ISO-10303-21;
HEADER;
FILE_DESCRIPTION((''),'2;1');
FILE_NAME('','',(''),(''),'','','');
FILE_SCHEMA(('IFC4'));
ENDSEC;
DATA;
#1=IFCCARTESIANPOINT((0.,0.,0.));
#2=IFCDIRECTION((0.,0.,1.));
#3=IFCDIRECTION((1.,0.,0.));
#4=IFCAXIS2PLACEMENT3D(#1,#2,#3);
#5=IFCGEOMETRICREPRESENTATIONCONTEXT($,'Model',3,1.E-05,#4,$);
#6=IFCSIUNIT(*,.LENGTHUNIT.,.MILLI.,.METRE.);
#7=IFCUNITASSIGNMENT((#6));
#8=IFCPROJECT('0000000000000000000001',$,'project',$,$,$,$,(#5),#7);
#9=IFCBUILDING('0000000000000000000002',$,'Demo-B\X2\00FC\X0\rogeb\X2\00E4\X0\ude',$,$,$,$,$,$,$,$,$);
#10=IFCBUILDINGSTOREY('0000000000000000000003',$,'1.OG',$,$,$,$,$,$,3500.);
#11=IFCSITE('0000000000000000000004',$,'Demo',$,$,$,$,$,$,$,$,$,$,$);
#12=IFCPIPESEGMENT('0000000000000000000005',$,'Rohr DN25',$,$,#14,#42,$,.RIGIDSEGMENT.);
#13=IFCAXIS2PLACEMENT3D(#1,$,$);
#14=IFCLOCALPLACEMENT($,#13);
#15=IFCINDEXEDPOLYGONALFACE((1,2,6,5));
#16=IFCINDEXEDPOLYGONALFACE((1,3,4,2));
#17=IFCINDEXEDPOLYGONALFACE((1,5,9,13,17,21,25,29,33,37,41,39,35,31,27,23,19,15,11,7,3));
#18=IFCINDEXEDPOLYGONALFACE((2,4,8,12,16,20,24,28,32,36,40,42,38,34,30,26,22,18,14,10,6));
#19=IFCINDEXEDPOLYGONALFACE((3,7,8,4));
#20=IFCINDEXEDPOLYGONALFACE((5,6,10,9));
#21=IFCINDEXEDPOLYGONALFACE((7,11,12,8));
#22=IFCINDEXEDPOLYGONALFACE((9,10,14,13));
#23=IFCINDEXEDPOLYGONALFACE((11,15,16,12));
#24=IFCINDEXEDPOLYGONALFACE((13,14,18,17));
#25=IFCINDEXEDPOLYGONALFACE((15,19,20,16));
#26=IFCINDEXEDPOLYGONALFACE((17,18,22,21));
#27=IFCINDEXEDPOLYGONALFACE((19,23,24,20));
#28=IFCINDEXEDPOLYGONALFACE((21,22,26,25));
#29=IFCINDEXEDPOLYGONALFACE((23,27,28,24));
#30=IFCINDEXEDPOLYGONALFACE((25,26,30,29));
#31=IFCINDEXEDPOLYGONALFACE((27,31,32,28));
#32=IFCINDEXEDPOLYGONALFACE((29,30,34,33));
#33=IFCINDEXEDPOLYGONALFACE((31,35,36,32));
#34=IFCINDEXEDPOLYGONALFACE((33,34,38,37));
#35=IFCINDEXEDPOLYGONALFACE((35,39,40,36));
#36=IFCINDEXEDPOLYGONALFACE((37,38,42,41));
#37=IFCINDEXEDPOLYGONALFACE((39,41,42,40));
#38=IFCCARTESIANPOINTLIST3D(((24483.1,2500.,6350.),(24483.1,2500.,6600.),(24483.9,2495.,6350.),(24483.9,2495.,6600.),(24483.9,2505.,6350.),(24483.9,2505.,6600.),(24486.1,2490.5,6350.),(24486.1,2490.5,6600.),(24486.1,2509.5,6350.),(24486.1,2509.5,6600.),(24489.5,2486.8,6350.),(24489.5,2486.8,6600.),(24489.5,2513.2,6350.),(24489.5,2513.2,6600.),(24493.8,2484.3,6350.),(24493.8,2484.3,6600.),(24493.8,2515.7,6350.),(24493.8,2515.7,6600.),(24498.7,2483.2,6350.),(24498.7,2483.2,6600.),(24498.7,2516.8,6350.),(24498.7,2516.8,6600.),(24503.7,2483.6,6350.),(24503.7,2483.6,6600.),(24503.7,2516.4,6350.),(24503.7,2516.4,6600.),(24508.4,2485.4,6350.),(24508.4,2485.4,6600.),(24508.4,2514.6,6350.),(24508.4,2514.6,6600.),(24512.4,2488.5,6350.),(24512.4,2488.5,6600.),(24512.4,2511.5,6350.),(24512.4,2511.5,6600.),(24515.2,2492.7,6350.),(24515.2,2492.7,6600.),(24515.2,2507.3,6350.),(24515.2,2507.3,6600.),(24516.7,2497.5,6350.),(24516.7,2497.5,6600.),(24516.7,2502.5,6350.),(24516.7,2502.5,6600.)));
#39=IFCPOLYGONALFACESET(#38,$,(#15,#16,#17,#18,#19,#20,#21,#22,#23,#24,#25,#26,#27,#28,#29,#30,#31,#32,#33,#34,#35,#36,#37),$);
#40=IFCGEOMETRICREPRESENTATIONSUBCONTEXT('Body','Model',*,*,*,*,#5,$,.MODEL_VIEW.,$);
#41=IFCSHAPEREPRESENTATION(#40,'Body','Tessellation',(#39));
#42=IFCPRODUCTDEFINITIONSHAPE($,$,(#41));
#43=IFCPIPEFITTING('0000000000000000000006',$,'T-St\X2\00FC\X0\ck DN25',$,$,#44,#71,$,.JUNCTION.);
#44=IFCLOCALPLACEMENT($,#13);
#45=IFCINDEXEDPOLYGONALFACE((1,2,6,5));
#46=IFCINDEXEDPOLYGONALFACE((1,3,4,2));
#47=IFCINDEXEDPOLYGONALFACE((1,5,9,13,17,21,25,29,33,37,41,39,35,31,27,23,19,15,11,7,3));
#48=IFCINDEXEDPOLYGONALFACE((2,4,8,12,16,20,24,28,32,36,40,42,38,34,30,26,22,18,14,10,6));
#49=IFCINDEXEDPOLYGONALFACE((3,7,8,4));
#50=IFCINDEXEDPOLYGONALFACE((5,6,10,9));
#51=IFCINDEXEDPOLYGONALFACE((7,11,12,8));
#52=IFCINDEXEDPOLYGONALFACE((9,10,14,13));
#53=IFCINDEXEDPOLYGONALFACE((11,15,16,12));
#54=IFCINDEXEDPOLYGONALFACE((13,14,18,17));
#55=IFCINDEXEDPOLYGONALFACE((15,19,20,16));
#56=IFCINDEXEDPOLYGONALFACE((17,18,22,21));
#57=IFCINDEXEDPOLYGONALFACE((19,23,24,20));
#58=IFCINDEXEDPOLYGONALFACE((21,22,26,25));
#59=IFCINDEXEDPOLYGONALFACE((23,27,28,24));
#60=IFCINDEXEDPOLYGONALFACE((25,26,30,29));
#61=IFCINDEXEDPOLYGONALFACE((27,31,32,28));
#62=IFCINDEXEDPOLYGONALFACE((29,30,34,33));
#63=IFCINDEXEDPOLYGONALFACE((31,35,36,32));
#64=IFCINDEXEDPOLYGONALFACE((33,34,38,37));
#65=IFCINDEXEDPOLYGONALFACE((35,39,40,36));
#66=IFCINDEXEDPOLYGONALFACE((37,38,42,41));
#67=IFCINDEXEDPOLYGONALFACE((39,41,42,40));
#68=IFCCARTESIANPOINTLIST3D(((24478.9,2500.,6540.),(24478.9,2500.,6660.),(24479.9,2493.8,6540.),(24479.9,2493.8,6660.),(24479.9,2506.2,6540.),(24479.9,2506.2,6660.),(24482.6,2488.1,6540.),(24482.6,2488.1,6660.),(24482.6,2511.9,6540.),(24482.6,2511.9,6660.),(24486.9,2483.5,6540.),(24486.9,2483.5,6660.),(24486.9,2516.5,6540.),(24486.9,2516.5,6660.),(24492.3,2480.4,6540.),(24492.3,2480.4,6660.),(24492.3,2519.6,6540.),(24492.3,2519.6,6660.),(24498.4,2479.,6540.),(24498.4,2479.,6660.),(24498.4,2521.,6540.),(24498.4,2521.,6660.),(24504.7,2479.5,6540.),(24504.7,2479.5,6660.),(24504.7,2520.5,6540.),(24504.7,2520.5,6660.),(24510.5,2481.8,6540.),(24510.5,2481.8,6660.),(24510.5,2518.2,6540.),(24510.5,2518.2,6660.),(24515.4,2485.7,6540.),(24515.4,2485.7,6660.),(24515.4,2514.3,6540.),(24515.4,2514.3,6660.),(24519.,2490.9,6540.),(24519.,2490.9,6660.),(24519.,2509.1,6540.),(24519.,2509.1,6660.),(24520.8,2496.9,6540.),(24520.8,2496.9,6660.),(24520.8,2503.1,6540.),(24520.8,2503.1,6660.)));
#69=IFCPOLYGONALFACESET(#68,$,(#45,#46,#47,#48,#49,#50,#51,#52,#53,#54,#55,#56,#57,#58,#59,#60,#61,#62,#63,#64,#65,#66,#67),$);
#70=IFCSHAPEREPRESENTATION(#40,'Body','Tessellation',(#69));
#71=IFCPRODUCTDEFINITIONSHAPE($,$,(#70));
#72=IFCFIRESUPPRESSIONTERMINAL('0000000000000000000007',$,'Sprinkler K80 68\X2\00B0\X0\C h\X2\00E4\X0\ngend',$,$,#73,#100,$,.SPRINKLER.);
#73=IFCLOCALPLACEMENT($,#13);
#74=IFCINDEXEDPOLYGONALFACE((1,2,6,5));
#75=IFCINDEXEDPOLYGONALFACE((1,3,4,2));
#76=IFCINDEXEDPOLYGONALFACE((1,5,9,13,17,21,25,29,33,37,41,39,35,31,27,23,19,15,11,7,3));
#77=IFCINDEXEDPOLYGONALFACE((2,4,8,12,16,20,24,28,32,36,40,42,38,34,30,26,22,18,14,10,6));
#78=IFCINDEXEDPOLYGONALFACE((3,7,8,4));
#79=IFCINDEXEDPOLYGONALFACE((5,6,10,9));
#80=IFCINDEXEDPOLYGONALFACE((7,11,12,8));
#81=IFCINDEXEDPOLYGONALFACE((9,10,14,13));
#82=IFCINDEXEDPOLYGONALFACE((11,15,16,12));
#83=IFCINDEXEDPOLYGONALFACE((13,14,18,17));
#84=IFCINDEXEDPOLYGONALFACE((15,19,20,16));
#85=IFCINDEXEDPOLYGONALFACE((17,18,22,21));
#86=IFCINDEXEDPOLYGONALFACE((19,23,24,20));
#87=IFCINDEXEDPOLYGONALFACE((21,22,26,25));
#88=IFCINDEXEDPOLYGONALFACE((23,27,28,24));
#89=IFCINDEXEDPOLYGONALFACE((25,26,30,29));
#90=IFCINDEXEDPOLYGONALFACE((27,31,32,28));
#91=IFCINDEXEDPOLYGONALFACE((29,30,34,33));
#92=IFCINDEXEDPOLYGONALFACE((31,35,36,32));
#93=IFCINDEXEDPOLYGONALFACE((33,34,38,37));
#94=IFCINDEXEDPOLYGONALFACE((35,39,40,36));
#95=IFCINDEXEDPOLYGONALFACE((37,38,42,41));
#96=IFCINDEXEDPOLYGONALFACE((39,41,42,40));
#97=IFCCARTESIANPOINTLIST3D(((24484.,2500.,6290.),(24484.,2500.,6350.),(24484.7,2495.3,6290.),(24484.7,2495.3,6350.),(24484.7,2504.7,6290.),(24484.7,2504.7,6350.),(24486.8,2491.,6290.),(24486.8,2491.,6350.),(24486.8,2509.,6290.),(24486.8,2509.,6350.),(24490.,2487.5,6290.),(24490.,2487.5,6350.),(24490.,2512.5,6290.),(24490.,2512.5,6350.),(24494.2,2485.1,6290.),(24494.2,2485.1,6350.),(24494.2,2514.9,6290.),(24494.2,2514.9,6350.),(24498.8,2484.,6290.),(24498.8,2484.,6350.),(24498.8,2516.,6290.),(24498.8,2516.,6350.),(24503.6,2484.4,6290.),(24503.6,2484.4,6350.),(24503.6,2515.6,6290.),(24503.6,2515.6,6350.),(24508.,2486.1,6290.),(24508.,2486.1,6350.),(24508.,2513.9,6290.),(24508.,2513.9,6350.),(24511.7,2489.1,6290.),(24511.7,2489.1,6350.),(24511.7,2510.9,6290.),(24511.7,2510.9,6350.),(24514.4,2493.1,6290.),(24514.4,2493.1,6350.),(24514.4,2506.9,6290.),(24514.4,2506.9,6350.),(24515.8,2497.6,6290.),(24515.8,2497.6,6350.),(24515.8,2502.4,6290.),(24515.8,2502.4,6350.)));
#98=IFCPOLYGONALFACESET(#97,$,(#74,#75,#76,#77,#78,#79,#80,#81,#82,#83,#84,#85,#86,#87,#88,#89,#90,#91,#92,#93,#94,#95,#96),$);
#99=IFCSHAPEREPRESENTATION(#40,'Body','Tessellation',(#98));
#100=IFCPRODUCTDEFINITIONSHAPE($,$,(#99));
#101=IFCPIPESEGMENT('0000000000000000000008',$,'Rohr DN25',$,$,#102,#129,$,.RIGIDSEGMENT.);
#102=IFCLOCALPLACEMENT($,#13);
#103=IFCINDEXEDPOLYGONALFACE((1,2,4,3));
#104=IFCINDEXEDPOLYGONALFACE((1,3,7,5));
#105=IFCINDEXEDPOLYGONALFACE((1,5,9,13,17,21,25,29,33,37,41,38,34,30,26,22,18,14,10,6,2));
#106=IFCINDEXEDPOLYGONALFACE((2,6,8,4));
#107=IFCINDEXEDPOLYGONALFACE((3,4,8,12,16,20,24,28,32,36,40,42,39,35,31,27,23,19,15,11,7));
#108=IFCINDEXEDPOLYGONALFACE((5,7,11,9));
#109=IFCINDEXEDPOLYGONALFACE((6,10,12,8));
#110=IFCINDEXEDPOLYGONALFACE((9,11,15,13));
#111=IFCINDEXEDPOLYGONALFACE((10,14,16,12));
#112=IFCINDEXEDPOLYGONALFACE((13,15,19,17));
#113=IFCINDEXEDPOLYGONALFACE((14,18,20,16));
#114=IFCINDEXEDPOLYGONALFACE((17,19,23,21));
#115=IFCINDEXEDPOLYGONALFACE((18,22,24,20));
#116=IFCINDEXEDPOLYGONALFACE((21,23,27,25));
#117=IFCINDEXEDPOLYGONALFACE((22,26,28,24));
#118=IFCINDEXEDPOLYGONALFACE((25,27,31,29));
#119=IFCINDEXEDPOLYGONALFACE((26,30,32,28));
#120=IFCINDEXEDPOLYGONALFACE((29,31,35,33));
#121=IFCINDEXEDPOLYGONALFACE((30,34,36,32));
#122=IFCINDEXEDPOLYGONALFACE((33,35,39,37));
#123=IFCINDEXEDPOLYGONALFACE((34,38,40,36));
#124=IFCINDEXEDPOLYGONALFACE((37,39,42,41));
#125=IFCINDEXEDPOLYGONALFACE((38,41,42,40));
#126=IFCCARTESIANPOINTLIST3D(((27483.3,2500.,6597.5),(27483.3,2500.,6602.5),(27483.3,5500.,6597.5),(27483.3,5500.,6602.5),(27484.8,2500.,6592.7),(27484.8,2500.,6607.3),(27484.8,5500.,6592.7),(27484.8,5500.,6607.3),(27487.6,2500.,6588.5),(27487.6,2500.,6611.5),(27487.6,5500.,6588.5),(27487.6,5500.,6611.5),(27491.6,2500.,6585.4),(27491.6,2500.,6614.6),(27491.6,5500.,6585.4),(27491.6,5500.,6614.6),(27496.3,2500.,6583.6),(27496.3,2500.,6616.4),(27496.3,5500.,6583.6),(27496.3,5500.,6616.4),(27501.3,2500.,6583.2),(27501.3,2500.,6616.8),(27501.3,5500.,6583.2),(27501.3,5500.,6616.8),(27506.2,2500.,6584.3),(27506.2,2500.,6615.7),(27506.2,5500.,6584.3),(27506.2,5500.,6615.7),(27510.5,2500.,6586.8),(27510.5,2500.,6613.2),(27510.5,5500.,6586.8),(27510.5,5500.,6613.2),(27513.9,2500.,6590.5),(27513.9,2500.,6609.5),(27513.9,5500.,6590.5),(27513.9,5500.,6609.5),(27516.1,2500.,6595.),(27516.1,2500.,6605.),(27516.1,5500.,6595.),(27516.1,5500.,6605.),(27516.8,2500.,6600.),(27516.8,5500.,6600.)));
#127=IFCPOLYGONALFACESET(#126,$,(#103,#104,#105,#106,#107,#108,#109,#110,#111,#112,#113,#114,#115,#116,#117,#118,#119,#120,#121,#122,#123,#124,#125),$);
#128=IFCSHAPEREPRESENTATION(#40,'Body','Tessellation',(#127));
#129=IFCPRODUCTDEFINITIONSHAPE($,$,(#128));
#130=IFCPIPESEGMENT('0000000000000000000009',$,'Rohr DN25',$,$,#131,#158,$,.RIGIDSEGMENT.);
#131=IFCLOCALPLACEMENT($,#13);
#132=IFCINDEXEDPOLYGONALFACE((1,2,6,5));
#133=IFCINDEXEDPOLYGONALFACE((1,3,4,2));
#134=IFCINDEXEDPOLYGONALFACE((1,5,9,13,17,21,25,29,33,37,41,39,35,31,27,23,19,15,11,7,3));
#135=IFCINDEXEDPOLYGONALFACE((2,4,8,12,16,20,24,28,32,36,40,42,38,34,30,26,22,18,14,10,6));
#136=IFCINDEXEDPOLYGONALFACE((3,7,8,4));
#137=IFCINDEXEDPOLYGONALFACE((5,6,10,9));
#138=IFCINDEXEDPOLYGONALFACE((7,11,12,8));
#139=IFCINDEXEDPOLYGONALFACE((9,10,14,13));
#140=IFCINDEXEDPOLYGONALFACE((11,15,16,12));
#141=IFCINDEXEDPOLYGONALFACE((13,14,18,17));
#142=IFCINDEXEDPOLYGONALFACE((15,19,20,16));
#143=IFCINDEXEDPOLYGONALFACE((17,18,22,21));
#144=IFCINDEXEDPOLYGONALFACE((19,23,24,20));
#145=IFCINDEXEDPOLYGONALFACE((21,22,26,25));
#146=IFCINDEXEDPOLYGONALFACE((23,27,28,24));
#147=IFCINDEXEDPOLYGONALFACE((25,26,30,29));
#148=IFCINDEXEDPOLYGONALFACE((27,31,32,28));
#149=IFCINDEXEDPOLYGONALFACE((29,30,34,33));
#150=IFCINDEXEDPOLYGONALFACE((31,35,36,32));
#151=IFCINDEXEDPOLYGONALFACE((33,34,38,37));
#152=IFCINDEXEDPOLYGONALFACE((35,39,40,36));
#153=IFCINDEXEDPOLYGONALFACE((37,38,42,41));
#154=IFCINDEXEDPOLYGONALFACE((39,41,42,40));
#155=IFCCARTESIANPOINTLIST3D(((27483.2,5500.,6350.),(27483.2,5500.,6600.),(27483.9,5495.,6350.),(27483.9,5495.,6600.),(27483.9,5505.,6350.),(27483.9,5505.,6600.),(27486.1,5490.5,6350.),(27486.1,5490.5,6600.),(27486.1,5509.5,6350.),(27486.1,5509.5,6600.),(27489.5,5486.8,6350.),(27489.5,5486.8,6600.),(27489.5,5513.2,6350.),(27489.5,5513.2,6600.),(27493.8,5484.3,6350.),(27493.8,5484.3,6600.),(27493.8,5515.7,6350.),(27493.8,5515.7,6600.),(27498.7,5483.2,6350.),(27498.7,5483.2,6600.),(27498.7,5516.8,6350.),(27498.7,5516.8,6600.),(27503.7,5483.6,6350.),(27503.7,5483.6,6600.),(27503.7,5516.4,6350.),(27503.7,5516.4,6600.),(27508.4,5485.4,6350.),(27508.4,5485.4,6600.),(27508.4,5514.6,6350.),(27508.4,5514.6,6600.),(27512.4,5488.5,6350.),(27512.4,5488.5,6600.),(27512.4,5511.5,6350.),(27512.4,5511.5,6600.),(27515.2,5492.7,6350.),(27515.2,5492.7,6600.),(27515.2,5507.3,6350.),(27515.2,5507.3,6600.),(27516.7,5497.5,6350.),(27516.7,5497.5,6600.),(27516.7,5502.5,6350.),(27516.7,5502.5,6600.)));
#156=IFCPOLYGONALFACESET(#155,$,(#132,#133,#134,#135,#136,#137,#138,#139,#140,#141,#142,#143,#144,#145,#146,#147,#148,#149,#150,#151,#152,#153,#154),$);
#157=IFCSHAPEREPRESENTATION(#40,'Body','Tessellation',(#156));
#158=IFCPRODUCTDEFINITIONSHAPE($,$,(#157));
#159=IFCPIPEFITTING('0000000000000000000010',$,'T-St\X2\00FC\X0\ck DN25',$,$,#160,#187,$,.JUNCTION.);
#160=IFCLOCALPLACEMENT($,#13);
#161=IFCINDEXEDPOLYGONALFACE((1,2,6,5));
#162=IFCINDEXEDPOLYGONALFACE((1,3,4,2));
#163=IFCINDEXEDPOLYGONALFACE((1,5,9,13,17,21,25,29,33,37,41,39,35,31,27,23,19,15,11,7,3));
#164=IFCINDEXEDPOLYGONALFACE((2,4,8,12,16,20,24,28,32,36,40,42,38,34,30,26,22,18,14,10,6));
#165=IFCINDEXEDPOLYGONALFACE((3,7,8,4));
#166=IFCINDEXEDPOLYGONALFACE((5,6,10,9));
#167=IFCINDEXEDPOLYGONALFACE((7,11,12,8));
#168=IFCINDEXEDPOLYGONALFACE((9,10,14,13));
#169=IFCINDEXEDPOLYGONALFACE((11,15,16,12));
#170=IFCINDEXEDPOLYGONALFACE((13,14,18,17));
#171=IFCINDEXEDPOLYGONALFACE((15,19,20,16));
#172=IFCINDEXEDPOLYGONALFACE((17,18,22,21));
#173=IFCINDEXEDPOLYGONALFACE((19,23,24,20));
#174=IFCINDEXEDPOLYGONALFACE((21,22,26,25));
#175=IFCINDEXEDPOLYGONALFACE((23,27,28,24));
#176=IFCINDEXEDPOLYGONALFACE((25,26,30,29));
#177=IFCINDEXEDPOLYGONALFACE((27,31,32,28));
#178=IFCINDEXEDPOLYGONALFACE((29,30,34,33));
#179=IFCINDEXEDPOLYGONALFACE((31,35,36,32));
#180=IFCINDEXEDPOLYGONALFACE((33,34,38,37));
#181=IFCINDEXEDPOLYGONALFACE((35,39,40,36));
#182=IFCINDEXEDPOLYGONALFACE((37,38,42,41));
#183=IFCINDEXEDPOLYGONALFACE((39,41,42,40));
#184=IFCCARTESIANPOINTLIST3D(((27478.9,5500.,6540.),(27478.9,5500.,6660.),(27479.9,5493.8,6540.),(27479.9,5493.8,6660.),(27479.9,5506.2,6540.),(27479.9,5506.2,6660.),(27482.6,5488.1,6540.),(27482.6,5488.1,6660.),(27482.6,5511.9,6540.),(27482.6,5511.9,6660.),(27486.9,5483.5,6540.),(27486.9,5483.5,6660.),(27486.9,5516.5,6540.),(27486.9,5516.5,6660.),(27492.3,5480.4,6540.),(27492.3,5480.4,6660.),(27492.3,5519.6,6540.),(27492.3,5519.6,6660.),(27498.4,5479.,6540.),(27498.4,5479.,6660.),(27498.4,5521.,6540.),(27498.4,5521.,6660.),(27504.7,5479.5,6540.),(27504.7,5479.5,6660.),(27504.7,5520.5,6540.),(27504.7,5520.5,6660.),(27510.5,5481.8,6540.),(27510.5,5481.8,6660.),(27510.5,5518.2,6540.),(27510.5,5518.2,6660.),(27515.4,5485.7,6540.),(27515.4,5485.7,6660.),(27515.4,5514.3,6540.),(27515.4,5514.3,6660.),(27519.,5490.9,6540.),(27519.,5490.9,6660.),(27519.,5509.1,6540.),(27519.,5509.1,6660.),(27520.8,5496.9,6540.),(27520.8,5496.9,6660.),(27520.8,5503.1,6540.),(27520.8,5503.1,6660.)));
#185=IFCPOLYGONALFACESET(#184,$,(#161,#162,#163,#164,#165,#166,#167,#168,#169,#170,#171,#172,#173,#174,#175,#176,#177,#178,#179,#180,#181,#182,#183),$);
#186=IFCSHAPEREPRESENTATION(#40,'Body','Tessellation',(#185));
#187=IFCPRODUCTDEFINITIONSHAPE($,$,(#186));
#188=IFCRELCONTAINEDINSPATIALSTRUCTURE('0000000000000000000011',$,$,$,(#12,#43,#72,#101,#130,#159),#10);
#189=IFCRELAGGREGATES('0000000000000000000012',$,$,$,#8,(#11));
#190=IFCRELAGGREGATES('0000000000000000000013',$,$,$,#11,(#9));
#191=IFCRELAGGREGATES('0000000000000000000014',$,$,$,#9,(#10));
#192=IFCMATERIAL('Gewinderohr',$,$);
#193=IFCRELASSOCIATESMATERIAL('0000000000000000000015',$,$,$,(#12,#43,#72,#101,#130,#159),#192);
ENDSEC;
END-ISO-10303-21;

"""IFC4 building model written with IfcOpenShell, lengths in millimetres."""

from ifc_helpers import new_model, si_unit, frame, origin_with_axes, place, context, subcontext, project, spatial, circle, extrude, material, element, save


model = new_model("IFC4")

# Units and contexts
model_context = context("Model", 3, precision=1e-05, world=origin_with_axes())
body_context = subcontext(model_context, "Body", "Model", "MODEL_VIEW")
ifc_project = project(units=[si_unit("LENGTHUNIT", "METRE", prefix="MILLI")], contexts=[model_context])

# Site, building, storey
site = spatial("IfcSite", under=ifc_project, Name="Demo")
building = spatial("IfcBuilding", under=site, Name="Demo-Bürogebäude")
storey = spatial("IfcBuildingStorey", under=building, Name="1.OG", Elevation=3500.0)

# Shared definitions
ifc_material_1 = material(Name="Gewinderohr")

# Pipe segment
pipe_segment_1_placement = place(None, frame((24500.0, 2500.0, 6600.0), z_axis=(0.0, 0.0, -1.0), x_axis=(-1.0, 0.0, 0.0)))
element("IfcPipeSegment", 1, at=pipe_segment_1_placement, inside=storey, material=ifc_material_1, Name="Rohr DN25", PredefinedType="RIGIDSEGMENT", context=body_context, shape_type="SweptSolid", body=[
    extrude(circle(Radius=16.9), origin_with_axes(), (0.0, 0.0, 1.0), 250.0),
])

# Pipe fitting
pipe_fitting_1_placement = place(None, frame((24500.0, 2500.0, 6660.0), z_axis=(0.0, 0.0, -1.0), x_axis=(-1.0, 0.0, 0.0)))
element("IfcPipeFitting", 2, at=pipe_fitting_1_placement, inside=storey, material=ifc_material_1, Name="T-Stück DN25", PredefinedType="JUNCTION", context=body_context, shape_type="SweptSolid", body=[
    extrude(circle(Radius=21.1), origin_with_axes(), (0.0, 0.0, 1.0), 120.0),
])

# Fire suppression terminal
fire_suppression_terminal_1_placement = place(None, frame((24500.0, 2500.0, 6350.0), z_axis=(0.0, 0.0, -1.0), x_axis=(-1.0, 0.0, 0.0)))
element("IfcFireSuppressionTerminal", 3, at=fire_suppression_terminal_1_placement, inside=storey, material=ifc_material_1, Name="Sprinkler K80 68°C hängend", PredefinedType="SPRINKLER", context=body_context, shape_type="SweptSolid", body=[
    extrude(circle(Radius=16.0), origin_with_axes(), (0.0, 0.0, 1.0), 60.0),
])

# Pipe segments
pipe_segment_2_placement = place(None, frame((27500.0, 5500.0, 6600.0), z_axis=(0.0, -1.0, 0.0), x_axis=(1.0, 0.0, 0.0)))
element("IfcPipeSegment", 4, at=pipe_segment_2_placement, inside=storey, material=ifc_material_1, Name="Rohr DN25", PredefinedType="RIGIDSEGMENT", context=body_context, shape_type="SweptSolid", body=[
    extrude(circle(Radius=16.9), origin_with_axes(), (0.0, 0.0, 1.0), 3000.0),
])
pipe_segment_3_placement = place(None, frame((27500.0, 5500.0, 6600.0), z_axis=(0.0, 0.0, -1.0), x_axis=(-1.0, 0.0, 0.0)))
element("IfcPipeSegment", 5, at=pipe_segment_3_placement, inside=storey, material=ifc_material_1, Name="Rohr DN25", PredefinedType="RIGIDSEGMENT", context=body_context, shape_type="SweptSolid", body=[
    extrude(circle(Radius=16.9), origin_with_axes(), (0.0, 0.0, 1.0), 250.0),
])

# Pipe fitting
pipe_fitting_2_placement = place(None, frame((27500.0, 5500.0, 6660.0), z_axis=(0.0, 0.0, -1.0), x_axis=(-1.0, 0.0, 0.0)))
element("IfcPipeFitting", 6, at=pipe_fitting_2_placement, inside=storey, material=ifc_material_1, Name="T-Stück DN25", PredefinedType="JUNCTION", context=body_context, shape_type="SweptSolid", body=[
    extrude(circle(Radius=21.1), origin_with_axes(), (0.0, 0.0, 1.0), 120.0),
])

save(model, "model.ifc")
